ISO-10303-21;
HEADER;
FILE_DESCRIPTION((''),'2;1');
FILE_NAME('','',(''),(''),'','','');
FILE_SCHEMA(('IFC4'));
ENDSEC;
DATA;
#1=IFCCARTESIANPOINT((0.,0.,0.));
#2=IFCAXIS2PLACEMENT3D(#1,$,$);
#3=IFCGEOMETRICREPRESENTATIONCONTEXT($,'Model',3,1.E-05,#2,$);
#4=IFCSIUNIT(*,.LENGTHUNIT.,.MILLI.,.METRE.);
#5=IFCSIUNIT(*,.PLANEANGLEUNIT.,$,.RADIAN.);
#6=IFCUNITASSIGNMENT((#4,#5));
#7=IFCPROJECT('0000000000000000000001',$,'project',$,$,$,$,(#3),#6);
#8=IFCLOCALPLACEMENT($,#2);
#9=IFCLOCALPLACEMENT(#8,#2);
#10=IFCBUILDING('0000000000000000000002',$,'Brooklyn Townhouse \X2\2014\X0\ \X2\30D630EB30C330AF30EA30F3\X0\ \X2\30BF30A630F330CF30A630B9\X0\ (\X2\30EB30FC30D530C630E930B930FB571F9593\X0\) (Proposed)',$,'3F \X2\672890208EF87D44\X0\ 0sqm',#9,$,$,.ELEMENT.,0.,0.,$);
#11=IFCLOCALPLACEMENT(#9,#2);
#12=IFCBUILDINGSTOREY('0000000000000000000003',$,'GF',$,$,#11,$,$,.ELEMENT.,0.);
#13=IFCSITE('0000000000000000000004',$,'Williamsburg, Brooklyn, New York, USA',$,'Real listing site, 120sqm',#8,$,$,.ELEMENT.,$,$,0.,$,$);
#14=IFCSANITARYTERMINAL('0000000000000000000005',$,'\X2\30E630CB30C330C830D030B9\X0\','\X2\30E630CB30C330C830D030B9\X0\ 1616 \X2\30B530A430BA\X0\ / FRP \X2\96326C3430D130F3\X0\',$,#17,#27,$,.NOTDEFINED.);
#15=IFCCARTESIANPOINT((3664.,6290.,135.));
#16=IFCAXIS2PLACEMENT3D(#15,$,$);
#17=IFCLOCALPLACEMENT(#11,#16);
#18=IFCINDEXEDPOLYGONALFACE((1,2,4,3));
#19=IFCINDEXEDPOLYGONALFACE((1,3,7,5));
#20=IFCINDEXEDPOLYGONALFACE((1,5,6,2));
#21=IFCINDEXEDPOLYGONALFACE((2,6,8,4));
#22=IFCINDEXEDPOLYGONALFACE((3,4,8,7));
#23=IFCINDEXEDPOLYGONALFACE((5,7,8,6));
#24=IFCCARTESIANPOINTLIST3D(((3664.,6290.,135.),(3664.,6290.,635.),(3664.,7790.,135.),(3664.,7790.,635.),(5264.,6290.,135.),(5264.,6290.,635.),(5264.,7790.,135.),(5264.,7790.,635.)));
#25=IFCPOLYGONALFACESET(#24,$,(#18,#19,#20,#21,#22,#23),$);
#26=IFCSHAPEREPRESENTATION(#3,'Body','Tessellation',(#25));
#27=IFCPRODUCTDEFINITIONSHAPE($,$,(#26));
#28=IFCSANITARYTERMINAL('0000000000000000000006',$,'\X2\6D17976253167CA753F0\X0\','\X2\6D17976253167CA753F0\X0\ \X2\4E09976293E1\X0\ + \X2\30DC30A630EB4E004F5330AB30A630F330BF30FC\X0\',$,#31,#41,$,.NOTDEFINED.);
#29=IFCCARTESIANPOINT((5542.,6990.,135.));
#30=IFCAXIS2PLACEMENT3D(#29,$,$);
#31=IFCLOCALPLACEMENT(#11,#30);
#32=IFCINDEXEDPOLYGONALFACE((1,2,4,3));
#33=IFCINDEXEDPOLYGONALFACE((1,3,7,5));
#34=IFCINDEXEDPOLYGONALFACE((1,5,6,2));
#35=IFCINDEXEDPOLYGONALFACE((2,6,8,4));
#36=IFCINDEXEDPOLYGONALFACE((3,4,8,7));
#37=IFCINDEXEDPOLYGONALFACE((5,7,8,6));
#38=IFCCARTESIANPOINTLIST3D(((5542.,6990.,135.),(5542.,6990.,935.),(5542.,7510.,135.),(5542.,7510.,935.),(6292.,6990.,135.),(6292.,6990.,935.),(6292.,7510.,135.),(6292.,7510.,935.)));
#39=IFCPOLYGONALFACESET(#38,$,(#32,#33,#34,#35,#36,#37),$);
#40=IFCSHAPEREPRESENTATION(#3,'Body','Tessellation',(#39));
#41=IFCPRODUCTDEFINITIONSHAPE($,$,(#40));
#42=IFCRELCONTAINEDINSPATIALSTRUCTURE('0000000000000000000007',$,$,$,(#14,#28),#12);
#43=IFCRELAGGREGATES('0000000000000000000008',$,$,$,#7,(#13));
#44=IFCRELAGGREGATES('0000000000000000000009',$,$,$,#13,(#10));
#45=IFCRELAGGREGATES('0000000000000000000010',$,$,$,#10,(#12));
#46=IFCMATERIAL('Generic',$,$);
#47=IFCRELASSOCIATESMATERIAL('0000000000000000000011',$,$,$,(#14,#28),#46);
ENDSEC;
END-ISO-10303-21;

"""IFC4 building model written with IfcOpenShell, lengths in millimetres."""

from ifc_helpers import new_model, si_unit, frame, frame_2d, origin, place, context, project, spatial, rectangle, extrude, material, element, save


model = new_model("IFC4")

# Units and contexts
model_context = context("Model", 3, precision=1e-05, world=origin())
ifc_project = project(units=[si_unit("LENGTHUNIT", "METRE", prefix="MILLI"), si_unit("PLANEANGLEUNIT", "RADIAN")], contexts=[model_context])

# Site, building, storey
site_placement = place(None, origin())
site = spatial("IfcSite", under=ifc_project, at=site_placement, Name="Williamsburg, Brooklyn, New York, USA", ObjectType="Real listing site, 120sqm", CompositionType="ELEMENT", RefElevation=0.0)
building_placement = place(site_placement, origin())
building = spatial("IfcBuilding", under=site, at=building_placement, Name="Brooklyn Townhouse — ブルックリン タウンハウス (ルーフテラス・土間) (Proposed)", ObjectType="3F 木造軸組 0sqm", CompositionType="ELEMENT", ElevationOfRefHeight=0.0, ElevationOfTerrain=0.0)
storey_placement = place(building_placement, origin())
storey = spatial("IfcBuildingStorey", under=building, at=storey_placement, Name="GF", CompositionType="ELEMENT", Elevation=0.0)

# Shared definitions
ifc_material_1 = material(Name="Generic")

# Sanitary terminals
sanitary_terminal_1_placement = place(storey_placement, frame((3664.0, 6290.0, 135.0)))
element("IfcSanitaryTerminal", 1, at=sanitary_terminal_1_placement, inside=storey, material=ifc_material_1, Name="ユニットバス", Description="ユニットバス 1616 サイズ / FRP 防水パン", PredefinedType="NOTDEFINED", context=model_context, shape_type="SweptSolid", body=[
    extrude(rectangle(XDim=1600.0, YDim=1500.0, at=frame_2d((800.0, 750.0))), frame((3664.0, 6290.0, 135.0)), (0.0, 0.0, 1.0), 500.0),
])
sanitary_terminal_2_placement = place(storey_placement, frame((5542.0, 6990.0, 135.0)))
element("IfcSanitaryTerminal", 2, at=sanitary_terminal_2_placement, inside=storey, material=ifc_material_1, Name="洗面化粧台", Description="洗面化粧台 三面鏡 + ボウル一体カウンター", PredefinedType="NOTDEFINED", context=model_context, shape_type="SweptSolid", body=[
    extrude(rectangle(XDim=750.0, YDim=520.0, at=frame_2d((375.0, 260.0))), frame((5542.0, 6990.0, 135.0)), (0.0, 0.0, 1.0), 800.0),
])

save(model, "model.ifc")
